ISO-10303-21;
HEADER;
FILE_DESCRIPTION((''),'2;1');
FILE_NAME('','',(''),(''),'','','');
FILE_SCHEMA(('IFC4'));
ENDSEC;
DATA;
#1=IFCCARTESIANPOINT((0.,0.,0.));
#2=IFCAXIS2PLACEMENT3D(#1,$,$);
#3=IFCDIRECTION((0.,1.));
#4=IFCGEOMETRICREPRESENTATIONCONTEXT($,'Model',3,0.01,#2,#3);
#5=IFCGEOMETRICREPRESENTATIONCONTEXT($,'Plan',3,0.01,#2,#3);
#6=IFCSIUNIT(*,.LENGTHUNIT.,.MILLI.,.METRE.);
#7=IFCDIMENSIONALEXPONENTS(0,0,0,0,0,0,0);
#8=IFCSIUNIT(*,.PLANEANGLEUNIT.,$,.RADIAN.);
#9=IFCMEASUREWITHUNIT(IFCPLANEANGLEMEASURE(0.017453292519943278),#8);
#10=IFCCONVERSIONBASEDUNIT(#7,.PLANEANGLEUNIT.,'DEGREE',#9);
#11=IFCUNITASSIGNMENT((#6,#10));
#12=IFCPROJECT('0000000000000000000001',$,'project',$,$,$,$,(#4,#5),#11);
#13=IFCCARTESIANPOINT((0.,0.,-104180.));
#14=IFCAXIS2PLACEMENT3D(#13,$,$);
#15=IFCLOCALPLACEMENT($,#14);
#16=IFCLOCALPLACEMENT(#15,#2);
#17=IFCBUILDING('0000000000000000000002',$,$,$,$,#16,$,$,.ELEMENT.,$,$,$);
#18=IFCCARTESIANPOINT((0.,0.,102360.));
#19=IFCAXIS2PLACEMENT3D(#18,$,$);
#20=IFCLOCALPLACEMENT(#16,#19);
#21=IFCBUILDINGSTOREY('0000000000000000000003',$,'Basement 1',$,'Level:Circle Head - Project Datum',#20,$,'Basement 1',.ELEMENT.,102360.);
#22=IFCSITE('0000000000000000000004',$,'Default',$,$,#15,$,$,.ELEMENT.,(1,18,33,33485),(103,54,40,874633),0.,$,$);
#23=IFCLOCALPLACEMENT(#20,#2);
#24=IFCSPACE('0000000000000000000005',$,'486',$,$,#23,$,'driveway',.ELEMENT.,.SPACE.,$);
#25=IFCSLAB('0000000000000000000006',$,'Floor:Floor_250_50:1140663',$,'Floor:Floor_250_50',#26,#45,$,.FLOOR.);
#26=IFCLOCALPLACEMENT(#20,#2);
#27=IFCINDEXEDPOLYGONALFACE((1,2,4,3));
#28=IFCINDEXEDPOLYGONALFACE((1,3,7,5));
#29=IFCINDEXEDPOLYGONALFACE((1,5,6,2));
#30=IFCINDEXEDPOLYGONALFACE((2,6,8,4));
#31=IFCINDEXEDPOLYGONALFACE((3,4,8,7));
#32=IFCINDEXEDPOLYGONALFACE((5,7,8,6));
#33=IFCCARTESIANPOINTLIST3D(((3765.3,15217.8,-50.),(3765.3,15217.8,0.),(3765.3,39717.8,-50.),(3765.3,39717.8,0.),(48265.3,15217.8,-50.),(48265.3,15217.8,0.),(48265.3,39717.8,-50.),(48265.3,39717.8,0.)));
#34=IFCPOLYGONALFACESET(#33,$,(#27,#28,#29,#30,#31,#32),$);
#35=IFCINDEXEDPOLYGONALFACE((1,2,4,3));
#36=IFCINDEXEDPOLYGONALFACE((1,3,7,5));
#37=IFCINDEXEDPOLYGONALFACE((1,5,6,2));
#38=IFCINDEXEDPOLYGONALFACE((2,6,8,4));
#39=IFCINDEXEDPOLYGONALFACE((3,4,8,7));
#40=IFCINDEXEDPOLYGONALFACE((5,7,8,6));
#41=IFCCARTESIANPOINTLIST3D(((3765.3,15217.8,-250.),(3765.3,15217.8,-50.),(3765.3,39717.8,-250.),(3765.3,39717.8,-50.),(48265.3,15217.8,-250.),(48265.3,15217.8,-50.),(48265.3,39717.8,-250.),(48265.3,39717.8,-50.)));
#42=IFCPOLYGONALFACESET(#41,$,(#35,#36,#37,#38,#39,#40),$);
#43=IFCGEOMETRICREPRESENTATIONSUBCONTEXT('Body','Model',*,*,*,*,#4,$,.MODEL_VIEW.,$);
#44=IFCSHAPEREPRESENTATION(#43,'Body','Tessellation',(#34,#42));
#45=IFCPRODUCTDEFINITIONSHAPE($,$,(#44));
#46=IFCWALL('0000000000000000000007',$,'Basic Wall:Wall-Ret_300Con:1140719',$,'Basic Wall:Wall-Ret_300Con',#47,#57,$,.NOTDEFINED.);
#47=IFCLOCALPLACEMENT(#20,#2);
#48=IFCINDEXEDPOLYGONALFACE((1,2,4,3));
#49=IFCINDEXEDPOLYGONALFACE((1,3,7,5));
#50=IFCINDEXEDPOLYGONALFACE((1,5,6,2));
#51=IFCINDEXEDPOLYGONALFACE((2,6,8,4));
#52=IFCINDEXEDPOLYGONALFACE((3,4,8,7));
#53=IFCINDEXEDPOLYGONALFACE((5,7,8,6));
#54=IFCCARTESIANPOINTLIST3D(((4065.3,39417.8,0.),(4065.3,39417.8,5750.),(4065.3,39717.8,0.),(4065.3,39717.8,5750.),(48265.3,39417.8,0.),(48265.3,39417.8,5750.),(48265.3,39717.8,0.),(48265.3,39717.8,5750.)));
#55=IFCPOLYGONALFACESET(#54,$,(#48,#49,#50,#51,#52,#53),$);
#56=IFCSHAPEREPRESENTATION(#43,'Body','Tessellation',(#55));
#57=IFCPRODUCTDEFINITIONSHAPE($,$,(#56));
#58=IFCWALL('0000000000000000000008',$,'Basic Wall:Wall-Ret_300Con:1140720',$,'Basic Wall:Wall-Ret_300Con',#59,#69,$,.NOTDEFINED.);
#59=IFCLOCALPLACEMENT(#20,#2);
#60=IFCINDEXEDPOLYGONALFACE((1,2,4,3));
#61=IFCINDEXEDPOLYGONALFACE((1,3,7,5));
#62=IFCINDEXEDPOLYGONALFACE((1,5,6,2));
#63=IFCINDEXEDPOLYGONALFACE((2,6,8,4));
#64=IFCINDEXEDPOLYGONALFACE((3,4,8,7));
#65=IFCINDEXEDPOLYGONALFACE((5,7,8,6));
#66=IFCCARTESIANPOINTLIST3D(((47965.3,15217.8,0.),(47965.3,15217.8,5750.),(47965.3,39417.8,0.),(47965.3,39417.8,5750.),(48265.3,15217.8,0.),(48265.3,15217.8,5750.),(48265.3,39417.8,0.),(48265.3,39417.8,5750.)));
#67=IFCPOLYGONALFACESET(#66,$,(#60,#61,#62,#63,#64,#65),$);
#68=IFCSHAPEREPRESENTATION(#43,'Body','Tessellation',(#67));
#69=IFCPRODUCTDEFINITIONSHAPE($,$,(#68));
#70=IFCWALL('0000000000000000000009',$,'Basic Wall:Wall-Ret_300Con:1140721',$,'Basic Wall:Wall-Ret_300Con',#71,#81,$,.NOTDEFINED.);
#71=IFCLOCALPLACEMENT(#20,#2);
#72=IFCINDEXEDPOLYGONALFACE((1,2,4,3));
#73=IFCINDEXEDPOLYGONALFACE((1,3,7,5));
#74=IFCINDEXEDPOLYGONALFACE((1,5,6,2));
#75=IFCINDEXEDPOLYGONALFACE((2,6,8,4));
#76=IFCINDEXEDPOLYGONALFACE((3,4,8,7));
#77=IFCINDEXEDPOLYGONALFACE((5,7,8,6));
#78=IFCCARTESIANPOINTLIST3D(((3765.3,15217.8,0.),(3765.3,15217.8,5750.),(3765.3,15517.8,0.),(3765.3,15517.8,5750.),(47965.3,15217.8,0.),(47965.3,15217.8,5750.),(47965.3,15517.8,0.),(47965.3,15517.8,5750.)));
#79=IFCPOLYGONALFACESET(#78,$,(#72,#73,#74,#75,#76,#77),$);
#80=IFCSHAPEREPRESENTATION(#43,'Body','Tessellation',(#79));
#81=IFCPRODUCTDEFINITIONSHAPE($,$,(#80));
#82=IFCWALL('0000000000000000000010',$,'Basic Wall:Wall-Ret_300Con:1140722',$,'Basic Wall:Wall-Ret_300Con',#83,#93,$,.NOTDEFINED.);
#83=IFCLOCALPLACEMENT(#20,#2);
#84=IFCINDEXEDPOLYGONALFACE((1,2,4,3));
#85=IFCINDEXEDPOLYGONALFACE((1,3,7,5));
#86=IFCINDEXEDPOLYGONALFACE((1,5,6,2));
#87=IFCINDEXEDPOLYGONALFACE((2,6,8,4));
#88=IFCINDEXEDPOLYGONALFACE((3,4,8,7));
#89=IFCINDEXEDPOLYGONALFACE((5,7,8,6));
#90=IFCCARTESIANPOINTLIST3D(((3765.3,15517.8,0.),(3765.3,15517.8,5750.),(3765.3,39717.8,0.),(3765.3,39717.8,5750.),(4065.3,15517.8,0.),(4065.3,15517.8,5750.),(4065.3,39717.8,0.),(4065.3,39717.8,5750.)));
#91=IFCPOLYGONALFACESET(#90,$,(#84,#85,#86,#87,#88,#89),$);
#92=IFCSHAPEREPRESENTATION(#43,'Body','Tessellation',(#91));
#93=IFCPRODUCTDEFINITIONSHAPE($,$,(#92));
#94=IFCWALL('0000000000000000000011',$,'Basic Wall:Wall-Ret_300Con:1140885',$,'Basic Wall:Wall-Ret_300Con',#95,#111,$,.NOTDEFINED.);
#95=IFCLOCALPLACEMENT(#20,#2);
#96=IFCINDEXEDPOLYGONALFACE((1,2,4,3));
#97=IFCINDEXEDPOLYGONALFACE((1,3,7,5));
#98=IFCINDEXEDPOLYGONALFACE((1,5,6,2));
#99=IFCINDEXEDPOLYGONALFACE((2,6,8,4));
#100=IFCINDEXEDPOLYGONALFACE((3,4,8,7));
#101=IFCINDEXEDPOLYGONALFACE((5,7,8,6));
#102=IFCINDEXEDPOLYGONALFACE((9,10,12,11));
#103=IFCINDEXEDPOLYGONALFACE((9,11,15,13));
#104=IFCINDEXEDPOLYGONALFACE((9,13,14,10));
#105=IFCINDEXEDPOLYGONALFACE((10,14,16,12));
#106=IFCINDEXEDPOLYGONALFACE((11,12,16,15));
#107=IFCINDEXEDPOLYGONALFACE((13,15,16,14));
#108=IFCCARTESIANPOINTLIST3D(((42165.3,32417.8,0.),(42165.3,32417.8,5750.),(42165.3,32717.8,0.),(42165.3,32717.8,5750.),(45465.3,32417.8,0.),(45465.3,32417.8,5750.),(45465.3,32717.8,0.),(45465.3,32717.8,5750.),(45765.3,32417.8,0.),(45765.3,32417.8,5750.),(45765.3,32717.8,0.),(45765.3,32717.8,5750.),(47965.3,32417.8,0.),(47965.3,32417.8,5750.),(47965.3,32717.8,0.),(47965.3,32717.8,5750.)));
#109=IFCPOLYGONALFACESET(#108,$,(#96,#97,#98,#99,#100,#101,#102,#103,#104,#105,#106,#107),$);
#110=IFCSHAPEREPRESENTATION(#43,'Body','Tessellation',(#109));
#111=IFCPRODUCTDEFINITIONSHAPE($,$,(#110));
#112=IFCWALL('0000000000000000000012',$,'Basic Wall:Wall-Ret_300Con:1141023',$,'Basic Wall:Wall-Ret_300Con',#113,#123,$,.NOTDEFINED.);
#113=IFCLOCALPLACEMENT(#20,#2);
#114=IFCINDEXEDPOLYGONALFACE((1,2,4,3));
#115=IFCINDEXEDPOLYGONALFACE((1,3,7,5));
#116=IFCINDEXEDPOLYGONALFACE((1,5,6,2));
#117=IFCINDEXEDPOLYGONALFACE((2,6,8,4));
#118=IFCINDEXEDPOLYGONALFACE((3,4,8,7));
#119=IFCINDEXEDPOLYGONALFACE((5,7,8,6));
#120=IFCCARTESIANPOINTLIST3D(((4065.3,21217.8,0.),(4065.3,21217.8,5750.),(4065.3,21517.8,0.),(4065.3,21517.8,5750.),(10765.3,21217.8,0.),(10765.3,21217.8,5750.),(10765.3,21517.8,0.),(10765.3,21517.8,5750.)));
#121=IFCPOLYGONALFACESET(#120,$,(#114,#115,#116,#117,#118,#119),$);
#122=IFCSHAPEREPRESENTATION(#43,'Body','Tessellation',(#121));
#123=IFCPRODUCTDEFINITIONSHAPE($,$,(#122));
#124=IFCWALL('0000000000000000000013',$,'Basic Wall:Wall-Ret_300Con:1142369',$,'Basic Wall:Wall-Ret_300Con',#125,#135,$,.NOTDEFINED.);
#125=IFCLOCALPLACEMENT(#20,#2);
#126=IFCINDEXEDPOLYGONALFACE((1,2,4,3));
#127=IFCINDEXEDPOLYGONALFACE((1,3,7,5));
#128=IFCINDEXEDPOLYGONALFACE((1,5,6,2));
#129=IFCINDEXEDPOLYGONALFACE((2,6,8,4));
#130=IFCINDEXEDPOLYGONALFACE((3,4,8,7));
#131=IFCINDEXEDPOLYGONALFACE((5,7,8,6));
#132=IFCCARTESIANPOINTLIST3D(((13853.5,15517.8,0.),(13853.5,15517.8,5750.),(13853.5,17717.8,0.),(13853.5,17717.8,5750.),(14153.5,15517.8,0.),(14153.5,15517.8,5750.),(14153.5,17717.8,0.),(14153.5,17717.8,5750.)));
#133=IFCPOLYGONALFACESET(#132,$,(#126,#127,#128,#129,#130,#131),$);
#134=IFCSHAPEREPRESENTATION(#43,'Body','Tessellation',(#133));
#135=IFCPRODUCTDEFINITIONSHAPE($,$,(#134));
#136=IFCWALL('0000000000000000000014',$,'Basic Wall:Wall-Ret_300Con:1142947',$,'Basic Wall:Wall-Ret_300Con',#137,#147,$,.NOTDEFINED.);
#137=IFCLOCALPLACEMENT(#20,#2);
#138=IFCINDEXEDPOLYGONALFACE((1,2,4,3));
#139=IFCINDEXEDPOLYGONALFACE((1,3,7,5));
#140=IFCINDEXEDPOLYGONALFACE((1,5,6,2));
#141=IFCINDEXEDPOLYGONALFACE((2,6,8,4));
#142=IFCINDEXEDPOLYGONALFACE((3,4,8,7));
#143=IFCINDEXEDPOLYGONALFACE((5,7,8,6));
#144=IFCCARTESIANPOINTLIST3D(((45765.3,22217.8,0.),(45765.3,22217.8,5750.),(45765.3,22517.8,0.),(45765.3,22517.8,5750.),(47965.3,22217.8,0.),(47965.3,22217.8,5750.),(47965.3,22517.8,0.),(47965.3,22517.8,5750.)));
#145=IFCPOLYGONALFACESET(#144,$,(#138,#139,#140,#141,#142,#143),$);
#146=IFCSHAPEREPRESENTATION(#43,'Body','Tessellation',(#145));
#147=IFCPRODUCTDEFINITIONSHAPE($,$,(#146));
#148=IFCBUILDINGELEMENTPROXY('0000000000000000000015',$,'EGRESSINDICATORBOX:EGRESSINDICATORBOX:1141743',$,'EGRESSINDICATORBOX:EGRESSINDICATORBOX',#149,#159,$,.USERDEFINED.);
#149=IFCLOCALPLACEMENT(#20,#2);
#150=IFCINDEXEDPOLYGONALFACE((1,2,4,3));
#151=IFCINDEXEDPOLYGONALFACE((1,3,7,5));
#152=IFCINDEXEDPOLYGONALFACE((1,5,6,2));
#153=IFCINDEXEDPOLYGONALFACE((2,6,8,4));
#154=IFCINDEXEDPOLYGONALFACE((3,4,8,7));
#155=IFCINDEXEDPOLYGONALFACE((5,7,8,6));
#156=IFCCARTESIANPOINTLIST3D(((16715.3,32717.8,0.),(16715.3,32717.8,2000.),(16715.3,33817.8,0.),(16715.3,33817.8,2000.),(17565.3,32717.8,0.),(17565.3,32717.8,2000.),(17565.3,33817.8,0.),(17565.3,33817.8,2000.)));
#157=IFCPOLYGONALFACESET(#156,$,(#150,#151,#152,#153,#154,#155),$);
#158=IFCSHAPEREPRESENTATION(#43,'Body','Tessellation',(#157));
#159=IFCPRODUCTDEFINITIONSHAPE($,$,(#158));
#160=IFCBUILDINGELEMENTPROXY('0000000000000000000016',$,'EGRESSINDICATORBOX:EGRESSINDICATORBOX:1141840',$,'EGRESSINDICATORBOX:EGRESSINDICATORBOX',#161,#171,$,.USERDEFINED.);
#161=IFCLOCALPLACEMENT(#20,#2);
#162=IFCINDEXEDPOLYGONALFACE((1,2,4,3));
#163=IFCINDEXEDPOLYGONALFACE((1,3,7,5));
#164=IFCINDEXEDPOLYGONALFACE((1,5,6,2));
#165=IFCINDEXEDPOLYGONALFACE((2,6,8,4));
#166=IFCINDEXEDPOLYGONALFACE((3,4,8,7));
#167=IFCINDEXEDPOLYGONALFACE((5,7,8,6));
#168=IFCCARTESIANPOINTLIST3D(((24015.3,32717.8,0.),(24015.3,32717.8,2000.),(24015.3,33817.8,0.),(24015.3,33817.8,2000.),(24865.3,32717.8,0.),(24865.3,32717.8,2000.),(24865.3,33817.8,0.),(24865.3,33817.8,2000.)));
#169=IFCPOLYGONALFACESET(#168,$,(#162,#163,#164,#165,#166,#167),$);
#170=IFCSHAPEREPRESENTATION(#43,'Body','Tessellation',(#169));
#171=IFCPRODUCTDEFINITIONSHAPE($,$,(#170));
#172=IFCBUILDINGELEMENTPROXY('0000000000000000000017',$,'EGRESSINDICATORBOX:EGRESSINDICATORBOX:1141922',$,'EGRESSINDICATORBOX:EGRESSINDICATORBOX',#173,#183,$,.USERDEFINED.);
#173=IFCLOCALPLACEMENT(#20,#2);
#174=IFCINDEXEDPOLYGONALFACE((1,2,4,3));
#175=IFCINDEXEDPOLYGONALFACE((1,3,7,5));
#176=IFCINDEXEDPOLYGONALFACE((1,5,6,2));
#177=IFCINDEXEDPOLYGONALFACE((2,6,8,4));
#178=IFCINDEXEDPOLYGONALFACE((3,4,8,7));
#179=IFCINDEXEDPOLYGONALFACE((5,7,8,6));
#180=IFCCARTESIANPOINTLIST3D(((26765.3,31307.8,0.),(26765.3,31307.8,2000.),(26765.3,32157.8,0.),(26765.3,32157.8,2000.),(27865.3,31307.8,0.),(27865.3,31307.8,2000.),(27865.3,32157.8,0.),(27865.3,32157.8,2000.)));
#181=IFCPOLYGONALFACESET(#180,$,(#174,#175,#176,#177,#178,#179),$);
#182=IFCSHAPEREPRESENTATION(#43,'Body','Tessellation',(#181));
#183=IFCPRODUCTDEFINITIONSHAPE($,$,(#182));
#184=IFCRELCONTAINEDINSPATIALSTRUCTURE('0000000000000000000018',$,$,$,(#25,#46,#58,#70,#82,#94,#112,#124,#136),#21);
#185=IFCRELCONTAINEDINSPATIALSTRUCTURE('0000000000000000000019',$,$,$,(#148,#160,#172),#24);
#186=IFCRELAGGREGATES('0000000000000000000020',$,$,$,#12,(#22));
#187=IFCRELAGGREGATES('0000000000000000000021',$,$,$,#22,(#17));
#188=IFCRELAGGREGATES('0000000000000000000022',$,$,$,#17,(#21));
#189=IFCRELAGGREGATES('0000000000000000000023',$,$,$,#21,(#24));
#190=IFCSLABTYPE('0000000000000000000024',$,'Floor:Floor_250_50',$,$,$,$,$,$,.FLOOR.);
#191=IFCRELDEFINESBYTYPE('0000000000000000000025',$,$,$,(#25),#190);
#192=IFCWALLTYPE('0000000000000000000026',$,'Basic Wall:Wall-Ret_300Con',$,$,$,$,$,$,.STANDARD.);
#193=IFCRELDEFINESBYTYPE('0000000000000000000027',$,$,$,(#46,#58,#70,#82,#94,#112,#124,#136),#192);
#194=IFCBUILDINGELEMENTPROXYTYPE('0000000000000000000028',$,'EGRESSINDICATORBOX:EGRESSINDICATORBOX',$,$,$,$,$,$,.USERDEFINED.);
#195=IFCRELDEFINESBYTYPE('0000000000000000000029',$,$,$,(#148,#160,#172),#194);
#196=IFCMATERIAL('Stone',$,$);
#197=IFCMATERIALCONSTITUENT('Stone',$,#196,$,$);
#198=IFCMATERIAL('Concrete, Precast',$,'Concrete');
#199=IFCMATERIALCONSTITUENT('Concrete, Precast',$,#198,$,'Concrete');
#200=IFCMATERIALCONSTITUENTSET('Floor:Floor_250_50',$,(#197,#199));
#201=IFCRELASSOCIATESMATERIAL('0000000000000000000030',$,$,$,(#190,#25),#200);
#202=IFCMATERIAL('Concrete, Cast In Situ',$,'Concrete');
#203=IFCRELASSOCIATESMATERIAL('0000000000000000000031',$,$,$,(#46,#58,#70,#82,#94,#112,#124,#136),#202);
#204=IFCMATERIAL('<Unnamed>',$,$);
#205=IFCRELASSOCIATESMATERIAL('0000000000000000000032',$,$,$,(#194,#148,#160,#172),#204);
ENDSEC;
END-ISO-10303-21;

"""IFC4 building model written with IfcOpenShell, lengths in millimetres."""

from ifc_helpers import new_model, entity, si_unit, converted_unit, direction, frame, origin, place, context, subcontext, project, spatial, indexed_curve, outline, extrude, source, transform, mapped, material, constituent, constituent_set, type_object, type_shapes, element, save


model = new_model("IFC4")

# Units and contexts
model_context = context("Model", 3, precision=0.01, world=origin(), true_north=direction((0.0, 1.0)))
plan_context = context("Plan", 3, precision=0.01, world=origin(), true_north=direction((0.0, 1.0)))
body_context = subcontext(model_context, "Body", "Model", "MODEL_VIEW")
ifc_project = project(units=[si_unit("LENGTHUNIT", "METRE", prefix="MILLI"), converted_unit("PLANEANGLEUNIT", "DEGREE", entity("IfcPlaneAngleMeasure", 0.017453292519943278), si_unit("PLANEANGLEUNIT", "RADIAN"), dimensions=[0, 0, 0, 0, 0, 0, 0])], contexts=[model_context, plan_context])

# Site, building, storey
site_placement = place(None, frame((0.0, 0.0, -104180.0)))
site = spatial("IfcSite", under=ifc_project, at=site_placement, Name="Default", CompositionType="ELEMENT", RefLatitude=(1, 18, 33, 33485), RefLongitude=(103, 54, 40, 874633), RefElevation=0.0)
building_placement = place(site_placement, origin())
building = spatial("IfcBuilding", under=site, at=building_placement, CompositionType="ELEMENT")
storey_placement = place(building_placement, frame((0.0, 0.0, 102360.0)))
storey = spatial("IfcBuildingStorey", under=building, at=storey_placement, Name="Basement 1", ObjectType="Level:Circle Head - Project Datum", LongName="Basement 1", CompositionType="ELEMENT", Elevation=102360.0)

# Slab
ifc_material_1 = material(Name="Stone")
ifc_constituent_1 = constituent(ifc_material_1, Name="Stone")
ifc_material_2 = material(Name="Concrete, Precast", Category="Concrete")
ifc_constituent_2 = constituent(ifc_material_2, Name="Concrete, Precast", Category="Concrete")
ifc_constituent_set = constituent_set(constituents=[ifc_constituent_1, ifc_constituent_2], Name="Floor:Floor_250_50")
slab_type = type_object("IfcSlabType", Name="Floor:Floor_250_50", PredefinedType="FLOOR", material=ifc_constituent_set)
slab_placement = place(storey_placement, origin())
element("IfcSlab", 1, at=slab_placement, inside=storey, type_object=slab_type, material=ifc_constituent_set, Name="Floor:Floor_250_50:1140663", ObjectType="Floor:Floor_250_50", PredefinedType="FLOOR", context=body_context, shape_type="SweptSolid", body=[
    extrude(outline(indexed_curve([(-22250.0, -12250.0), (22250.0, -12250.0), (22250.0, 12250.0), (-22250.0, 12250.0), (-22250.0, -12250.0)], self_intersect=False)), frame((26015.3, 27467.8, -50.0), z_axis=(0.0, 0.0, 1.0), x_axis=(-1.0, 0.0, 0.0)), (0.0, 0.0, 1.0), 50.0),
    extrude(outline(indexed_curve([(-22250.0, -12250.0), (22250.0, -12250.0), (22250.0, 12250.0), (-22250.0, 12250.0), (-22250.0, -12250.0)], self_intersect=False)), frame((26015.3, 27467.8, -250.0), z_axis=(0.0, 0.0, 1.0), x_axis=(-1.0, 0.0, 0.0)), (0.0, 0.0, 1.0), 200.0),
])

# Walls
ifc_material_3 = material(Name="Concrete, Cast In Situ", Category="Concrete")
wall_type = type_object("IfcWallType", Name="Basic Wall:Wall-Ret_300Con", PredefinedType="STANDARD")
wall_1_placement = place(storey_placement, frame((48265.3, 39567.8, 0.0), z_axis=(0.0, 0.0, 1.0), x_axis=(-1.0, 0.0, 0.0)))
element("IfcWall", 2, at=wall_1_placement, inside=storey, type_object=wall_type, material=ifc_material_3, Name="Basic Wall:Wall-Ret_300Con:1140719", ObjectType="Basic Wall:Wall-Ret_300Con", PredefinedType="NOTDEFINED", context=body_context, shape_type="SweptSolid", body=[
    extrude(outline(indexed_curve([(44200.0, 150.0), (0.0, 150.0), (0.0, -150.0), (44200.0, -150.0), (44200.0, 150.0)], self_intersect=False)), origin(), (0.0, 0.0, 1.0), 5750.0),
])
wall_2_placement = place(storey_placement, frame((48115.3, 15217.8, 0.0), z_axis=(0.0, 0.0, 1.0), x_axis=(0.0, 1.0, 0.0)))
element("IfcWall", 3, at=wall_2_placement, inside=storey, type_object=wall_type, material=ifc_material_3, Name="Basic Wall:Wall-Ret_300Con:1140720", ObjectType="Basic Wall:Wall-Ret_300Con", PredefinedType="NOTDEFINED", context=body_context, shape_type="SweptSolid", body=[
    extrude(outline(indexed_curve([(24200.0, 150.0), (0.0, 150.0), (0.0, -150.0), (24200.0, -150.0), (24200.0, 150.0)], self_intersect=False)), origin(), (0.0, 0.0, 1.0), 5750.0),
])
wall_3_placement = place(storey_placement, frame((3765.3, 15367.8, 0.0)))
element("IfcWall", 4, at=wall_3_placement, inside=storey, type_object=wall_type, material=ifc_material_3, Name="Basic Wall:Wall-Ret_300Con:1140721", ObjectType="Basic Wall:Wall-Ret_300Con", PredefinedType="NOTDEFINED", context=body_context, shape_type="SweptSolid", body=[
    extrude(outline(indexed_curve([(44200.0, 150.0), (0.0, 150.0), (0.0, -150.0), (44200.0, -150.0), (44200.0, 150.0)], self_intersect=False)), origin(), (0.0, 0.0, 1.0), 5750.0),
])
wall_4_placement = place(storey_placement, frame((3915.3, 39717.8, 0.0), z_axis=(0.0, 0.0, 1.0), x_axis=(0.0, -1.0, 0.0)))
element("IfcWall", 5, at=wall_4_placement, inside=storey, type_object=wall_type, material=ifc_material_3, Name="Basic Wall:Wall-Ret_300Con:1140722", ObjectType="Basic Wall:Wall-Ret_300Con", PredefinedType="NOTDEFINED", context=body_context, shape_type="SweptSolid", body=[
    extrude(outline(indexed_curve([(24200.0, 150.0), (0.0, 150.0), (0.0, -150.0), (24200.0, -150.0), (24200.0, 150.0)], self_intersect=False)), origin(), (0.0, 0.0, 1.0), 5750.0),
])

# Wall, opening
wall_5_placement = place(storey_placement, frame((47965.3, 32567.8, 0.0), z_axis=(0.0, 0.0, 1.0), x_axis=(-1.0, 0.0, 0.0)))
wall_5 = element("IfcWall", 6, at=wall_5_placement, inside=storey, type_object=wall_type, material=ifc_material_3, Name="Basic Wall:Wall-Ret_300Con:1140885", ObjectType="Basic Wall:Wall-Ret_300Con", PredefinedType="NOTDEFINED", context=body_context, shape_type="SweptSolid", body=[
    extrude(outline(indexed_curve([(5800.0, 150.0), (0.0, 150.0), (0.0, -150.0), (5800.0, -150.0), (5800.0, 150.0)], self_intersect=False)), origin(), (0.0, 0.0, 1.0), 5750.0),
])
opening_placement = place(storey_placement, frame((47965.3, 32567.8, 0.0), z_axis=(0.0, 0.0, 1.0), x_axis=(-1.0, 0.0, 0.0)))
element("IfcOpeningElement", 7, at=opening_placement, cuts=wall_5, PredefinedType="OPENING", context=body_context, shape_type="SweptSolid", body=[
    extrude(outline(indexed_curve([(-2875.0, -150.0), (2875.0, -150.0), (2875.0, 150.0), (-2875.0, 150.0), (-2875.0, -150.0)], self_intersect=False)), frame((2500.0, 0.0, 2875.0), z_axis=(-1.0, 0.0, 0.0), x_axis=(0.0, 0.0, 1.0)), (0.0, 0.0, 1.0), 300.0),
])

# Walls
wall_6_placement = place(storey_placement, frame((4065.3, 21367.8, 0.0)))
element("IfcWall", 8, at=wall_6_placement, inside=storey, type_object=wall_type, material=ifc_material_3, Name="Basic Wall:Wall-Ret_300Con:1141023", ObjectType="Basic Wall:Wall-Ret_300Con", PredefinedType="NOTDEFINED", context=body_context, shape_type="SweptSolid", body=[
    extrude(outline(indexed_curve([(6700.0, 150.0), (0.0, 150.0), (0.0, -150.0), (6700.0, -150.0), (6700.0, 150.0)], self_intersect=False)), origin(), (0.0, 0.0, 1.0), 5750.0),
])
wall_7_placement = place(storey_placement, frame((14003.5, 17717.8, 0.0), z_axis=(0.0, 0.0, 1.0), x_axis=(0.0, -1.0, 0.0)))
element("IfcWall", 9, at=wall_7_placement, inside=storey, type_object=wall_type, material=ifc_material_3, Name="Basic Wall:Wall-Ret_300Con:1142369", ObjectType="Basic Wall:Wall-Ret_300Con", PredefinedType="NOTDEFINED", context=body_context, shape_type="SweptSolid", body=[
    extrude(outline(indexed_curve([(2200.0, 150.0), (0.0, 150.0), (0.0, -150.0), (2200.0, -150.0), (2200.0, 150.0)], self_intersect=False)), origin(), (0.0, 0.0, 1.0), 5750.0),
])
wall_8_placement = place(storey_placement, frame((47965.3, 22367.8, 0.0), z_axis=(0.0, 0.0, 1.0), x_axis=(-1.0, 0.0, 0.0)))
element("IfcWall", 10, at=wall_8_placement, inside=storey, type_object=wall_type, material=ifc_material_3, Name="Basic Wall:Wall-Ret_300Con:1142947", ObjectType="Basic Wall:Wall-Ret_300Con", PredefinedType="NOTDEFINED", context=body_context, shape_type="SweptSolid", body=[
    extrude(outline(indexed_curve([(2200.0, 150.0), (0.0, 150.0), (0.0, -150.0), (2200.0, -150.0), (2200.0, 150.0)], self_intersect=False)), origin(), (0.0, 0.0, 1.0), 5750.0),
])

# Shared definitions
space_1_placement = place(storey_placement, origin())
space_1 = spatial("IfcSpace", under=storey, at=space_1_placement, Name="486", LongName="driveway", CompositionType="ELEMENT", PredefinedType="SPACE")

# Building element proxies
ifc_material_4 = material(Name="<Unnamed>")
building_element_proxy_type_1 = type_object("IfcBuildingElementProxyType", Name="EGRESSINDICATORBOX:EGRESSINDICATORBOX", PredefinedType="USERDEFINED", material=ifc_material_4)
shared_shape_1 = source(origin(), body_context, "Body", "SweptSolid", [
    extrude(outline(indexed_curve([(-550.0, -425.0), (550.0, -425.0), (550.0, 425.0), (-550.0, 425.0), (-550.0, -425.0)], self_intersect=False)), frame((0.0, 0.0, 0.0), z_axis=(0.0, 0.0, 1.0), x_axis=(0.0, 1.0, 0.0)), (0.0, 0.0, 1.0), 2000.0),
])
type_shapes(building_element_proxy_type_1, [shared_shape_1])
for number, where, z_axis, x_axis, name in (
    (11, (17140.3, 33267.8, 0.0), (0.0, 0.0, 1.0), (-1.0, 0.0, 0.0), "EGRESSINDICATORBOX:EGRESSINDICATORBOX:1141743"),
    (12, (24440.3, 33267.8, 0.0), (0.0, 0.0, 1.0), (-1.0, 0.0, 0.0), "EGRESSINDICATORBOX:EGRESSINDICATORBOX:1141840"),
    (13, (27315.3, 31732.8, 0.0), (0.0, 0.0, 1.0), (0.0, 1.0, 0.0), "EGRESSINDICATORBOX:EGRESSINDICATORBOX:1141922"),
):
    element("IfcBuildingElementProxy", number, at=place(space_1_placement, frame(where, z_axis=z_axis, x_axis=x_axis)), inside=space_1, type_object=building_element_proxy_type_1, material=ifc_material_4, Name=name, ObjectType="EGRESSINDICATORBOX:EGRESSINDICATORBOX", PredefinedType="USERDEFINED", context=body_context, shape_type="MappedRepresentation", body=[
        mapped(shared_shape_1, transform((0.0, 0.0, 0.0), scale=1.0)),
    ])

save(model, "model.ifc")
